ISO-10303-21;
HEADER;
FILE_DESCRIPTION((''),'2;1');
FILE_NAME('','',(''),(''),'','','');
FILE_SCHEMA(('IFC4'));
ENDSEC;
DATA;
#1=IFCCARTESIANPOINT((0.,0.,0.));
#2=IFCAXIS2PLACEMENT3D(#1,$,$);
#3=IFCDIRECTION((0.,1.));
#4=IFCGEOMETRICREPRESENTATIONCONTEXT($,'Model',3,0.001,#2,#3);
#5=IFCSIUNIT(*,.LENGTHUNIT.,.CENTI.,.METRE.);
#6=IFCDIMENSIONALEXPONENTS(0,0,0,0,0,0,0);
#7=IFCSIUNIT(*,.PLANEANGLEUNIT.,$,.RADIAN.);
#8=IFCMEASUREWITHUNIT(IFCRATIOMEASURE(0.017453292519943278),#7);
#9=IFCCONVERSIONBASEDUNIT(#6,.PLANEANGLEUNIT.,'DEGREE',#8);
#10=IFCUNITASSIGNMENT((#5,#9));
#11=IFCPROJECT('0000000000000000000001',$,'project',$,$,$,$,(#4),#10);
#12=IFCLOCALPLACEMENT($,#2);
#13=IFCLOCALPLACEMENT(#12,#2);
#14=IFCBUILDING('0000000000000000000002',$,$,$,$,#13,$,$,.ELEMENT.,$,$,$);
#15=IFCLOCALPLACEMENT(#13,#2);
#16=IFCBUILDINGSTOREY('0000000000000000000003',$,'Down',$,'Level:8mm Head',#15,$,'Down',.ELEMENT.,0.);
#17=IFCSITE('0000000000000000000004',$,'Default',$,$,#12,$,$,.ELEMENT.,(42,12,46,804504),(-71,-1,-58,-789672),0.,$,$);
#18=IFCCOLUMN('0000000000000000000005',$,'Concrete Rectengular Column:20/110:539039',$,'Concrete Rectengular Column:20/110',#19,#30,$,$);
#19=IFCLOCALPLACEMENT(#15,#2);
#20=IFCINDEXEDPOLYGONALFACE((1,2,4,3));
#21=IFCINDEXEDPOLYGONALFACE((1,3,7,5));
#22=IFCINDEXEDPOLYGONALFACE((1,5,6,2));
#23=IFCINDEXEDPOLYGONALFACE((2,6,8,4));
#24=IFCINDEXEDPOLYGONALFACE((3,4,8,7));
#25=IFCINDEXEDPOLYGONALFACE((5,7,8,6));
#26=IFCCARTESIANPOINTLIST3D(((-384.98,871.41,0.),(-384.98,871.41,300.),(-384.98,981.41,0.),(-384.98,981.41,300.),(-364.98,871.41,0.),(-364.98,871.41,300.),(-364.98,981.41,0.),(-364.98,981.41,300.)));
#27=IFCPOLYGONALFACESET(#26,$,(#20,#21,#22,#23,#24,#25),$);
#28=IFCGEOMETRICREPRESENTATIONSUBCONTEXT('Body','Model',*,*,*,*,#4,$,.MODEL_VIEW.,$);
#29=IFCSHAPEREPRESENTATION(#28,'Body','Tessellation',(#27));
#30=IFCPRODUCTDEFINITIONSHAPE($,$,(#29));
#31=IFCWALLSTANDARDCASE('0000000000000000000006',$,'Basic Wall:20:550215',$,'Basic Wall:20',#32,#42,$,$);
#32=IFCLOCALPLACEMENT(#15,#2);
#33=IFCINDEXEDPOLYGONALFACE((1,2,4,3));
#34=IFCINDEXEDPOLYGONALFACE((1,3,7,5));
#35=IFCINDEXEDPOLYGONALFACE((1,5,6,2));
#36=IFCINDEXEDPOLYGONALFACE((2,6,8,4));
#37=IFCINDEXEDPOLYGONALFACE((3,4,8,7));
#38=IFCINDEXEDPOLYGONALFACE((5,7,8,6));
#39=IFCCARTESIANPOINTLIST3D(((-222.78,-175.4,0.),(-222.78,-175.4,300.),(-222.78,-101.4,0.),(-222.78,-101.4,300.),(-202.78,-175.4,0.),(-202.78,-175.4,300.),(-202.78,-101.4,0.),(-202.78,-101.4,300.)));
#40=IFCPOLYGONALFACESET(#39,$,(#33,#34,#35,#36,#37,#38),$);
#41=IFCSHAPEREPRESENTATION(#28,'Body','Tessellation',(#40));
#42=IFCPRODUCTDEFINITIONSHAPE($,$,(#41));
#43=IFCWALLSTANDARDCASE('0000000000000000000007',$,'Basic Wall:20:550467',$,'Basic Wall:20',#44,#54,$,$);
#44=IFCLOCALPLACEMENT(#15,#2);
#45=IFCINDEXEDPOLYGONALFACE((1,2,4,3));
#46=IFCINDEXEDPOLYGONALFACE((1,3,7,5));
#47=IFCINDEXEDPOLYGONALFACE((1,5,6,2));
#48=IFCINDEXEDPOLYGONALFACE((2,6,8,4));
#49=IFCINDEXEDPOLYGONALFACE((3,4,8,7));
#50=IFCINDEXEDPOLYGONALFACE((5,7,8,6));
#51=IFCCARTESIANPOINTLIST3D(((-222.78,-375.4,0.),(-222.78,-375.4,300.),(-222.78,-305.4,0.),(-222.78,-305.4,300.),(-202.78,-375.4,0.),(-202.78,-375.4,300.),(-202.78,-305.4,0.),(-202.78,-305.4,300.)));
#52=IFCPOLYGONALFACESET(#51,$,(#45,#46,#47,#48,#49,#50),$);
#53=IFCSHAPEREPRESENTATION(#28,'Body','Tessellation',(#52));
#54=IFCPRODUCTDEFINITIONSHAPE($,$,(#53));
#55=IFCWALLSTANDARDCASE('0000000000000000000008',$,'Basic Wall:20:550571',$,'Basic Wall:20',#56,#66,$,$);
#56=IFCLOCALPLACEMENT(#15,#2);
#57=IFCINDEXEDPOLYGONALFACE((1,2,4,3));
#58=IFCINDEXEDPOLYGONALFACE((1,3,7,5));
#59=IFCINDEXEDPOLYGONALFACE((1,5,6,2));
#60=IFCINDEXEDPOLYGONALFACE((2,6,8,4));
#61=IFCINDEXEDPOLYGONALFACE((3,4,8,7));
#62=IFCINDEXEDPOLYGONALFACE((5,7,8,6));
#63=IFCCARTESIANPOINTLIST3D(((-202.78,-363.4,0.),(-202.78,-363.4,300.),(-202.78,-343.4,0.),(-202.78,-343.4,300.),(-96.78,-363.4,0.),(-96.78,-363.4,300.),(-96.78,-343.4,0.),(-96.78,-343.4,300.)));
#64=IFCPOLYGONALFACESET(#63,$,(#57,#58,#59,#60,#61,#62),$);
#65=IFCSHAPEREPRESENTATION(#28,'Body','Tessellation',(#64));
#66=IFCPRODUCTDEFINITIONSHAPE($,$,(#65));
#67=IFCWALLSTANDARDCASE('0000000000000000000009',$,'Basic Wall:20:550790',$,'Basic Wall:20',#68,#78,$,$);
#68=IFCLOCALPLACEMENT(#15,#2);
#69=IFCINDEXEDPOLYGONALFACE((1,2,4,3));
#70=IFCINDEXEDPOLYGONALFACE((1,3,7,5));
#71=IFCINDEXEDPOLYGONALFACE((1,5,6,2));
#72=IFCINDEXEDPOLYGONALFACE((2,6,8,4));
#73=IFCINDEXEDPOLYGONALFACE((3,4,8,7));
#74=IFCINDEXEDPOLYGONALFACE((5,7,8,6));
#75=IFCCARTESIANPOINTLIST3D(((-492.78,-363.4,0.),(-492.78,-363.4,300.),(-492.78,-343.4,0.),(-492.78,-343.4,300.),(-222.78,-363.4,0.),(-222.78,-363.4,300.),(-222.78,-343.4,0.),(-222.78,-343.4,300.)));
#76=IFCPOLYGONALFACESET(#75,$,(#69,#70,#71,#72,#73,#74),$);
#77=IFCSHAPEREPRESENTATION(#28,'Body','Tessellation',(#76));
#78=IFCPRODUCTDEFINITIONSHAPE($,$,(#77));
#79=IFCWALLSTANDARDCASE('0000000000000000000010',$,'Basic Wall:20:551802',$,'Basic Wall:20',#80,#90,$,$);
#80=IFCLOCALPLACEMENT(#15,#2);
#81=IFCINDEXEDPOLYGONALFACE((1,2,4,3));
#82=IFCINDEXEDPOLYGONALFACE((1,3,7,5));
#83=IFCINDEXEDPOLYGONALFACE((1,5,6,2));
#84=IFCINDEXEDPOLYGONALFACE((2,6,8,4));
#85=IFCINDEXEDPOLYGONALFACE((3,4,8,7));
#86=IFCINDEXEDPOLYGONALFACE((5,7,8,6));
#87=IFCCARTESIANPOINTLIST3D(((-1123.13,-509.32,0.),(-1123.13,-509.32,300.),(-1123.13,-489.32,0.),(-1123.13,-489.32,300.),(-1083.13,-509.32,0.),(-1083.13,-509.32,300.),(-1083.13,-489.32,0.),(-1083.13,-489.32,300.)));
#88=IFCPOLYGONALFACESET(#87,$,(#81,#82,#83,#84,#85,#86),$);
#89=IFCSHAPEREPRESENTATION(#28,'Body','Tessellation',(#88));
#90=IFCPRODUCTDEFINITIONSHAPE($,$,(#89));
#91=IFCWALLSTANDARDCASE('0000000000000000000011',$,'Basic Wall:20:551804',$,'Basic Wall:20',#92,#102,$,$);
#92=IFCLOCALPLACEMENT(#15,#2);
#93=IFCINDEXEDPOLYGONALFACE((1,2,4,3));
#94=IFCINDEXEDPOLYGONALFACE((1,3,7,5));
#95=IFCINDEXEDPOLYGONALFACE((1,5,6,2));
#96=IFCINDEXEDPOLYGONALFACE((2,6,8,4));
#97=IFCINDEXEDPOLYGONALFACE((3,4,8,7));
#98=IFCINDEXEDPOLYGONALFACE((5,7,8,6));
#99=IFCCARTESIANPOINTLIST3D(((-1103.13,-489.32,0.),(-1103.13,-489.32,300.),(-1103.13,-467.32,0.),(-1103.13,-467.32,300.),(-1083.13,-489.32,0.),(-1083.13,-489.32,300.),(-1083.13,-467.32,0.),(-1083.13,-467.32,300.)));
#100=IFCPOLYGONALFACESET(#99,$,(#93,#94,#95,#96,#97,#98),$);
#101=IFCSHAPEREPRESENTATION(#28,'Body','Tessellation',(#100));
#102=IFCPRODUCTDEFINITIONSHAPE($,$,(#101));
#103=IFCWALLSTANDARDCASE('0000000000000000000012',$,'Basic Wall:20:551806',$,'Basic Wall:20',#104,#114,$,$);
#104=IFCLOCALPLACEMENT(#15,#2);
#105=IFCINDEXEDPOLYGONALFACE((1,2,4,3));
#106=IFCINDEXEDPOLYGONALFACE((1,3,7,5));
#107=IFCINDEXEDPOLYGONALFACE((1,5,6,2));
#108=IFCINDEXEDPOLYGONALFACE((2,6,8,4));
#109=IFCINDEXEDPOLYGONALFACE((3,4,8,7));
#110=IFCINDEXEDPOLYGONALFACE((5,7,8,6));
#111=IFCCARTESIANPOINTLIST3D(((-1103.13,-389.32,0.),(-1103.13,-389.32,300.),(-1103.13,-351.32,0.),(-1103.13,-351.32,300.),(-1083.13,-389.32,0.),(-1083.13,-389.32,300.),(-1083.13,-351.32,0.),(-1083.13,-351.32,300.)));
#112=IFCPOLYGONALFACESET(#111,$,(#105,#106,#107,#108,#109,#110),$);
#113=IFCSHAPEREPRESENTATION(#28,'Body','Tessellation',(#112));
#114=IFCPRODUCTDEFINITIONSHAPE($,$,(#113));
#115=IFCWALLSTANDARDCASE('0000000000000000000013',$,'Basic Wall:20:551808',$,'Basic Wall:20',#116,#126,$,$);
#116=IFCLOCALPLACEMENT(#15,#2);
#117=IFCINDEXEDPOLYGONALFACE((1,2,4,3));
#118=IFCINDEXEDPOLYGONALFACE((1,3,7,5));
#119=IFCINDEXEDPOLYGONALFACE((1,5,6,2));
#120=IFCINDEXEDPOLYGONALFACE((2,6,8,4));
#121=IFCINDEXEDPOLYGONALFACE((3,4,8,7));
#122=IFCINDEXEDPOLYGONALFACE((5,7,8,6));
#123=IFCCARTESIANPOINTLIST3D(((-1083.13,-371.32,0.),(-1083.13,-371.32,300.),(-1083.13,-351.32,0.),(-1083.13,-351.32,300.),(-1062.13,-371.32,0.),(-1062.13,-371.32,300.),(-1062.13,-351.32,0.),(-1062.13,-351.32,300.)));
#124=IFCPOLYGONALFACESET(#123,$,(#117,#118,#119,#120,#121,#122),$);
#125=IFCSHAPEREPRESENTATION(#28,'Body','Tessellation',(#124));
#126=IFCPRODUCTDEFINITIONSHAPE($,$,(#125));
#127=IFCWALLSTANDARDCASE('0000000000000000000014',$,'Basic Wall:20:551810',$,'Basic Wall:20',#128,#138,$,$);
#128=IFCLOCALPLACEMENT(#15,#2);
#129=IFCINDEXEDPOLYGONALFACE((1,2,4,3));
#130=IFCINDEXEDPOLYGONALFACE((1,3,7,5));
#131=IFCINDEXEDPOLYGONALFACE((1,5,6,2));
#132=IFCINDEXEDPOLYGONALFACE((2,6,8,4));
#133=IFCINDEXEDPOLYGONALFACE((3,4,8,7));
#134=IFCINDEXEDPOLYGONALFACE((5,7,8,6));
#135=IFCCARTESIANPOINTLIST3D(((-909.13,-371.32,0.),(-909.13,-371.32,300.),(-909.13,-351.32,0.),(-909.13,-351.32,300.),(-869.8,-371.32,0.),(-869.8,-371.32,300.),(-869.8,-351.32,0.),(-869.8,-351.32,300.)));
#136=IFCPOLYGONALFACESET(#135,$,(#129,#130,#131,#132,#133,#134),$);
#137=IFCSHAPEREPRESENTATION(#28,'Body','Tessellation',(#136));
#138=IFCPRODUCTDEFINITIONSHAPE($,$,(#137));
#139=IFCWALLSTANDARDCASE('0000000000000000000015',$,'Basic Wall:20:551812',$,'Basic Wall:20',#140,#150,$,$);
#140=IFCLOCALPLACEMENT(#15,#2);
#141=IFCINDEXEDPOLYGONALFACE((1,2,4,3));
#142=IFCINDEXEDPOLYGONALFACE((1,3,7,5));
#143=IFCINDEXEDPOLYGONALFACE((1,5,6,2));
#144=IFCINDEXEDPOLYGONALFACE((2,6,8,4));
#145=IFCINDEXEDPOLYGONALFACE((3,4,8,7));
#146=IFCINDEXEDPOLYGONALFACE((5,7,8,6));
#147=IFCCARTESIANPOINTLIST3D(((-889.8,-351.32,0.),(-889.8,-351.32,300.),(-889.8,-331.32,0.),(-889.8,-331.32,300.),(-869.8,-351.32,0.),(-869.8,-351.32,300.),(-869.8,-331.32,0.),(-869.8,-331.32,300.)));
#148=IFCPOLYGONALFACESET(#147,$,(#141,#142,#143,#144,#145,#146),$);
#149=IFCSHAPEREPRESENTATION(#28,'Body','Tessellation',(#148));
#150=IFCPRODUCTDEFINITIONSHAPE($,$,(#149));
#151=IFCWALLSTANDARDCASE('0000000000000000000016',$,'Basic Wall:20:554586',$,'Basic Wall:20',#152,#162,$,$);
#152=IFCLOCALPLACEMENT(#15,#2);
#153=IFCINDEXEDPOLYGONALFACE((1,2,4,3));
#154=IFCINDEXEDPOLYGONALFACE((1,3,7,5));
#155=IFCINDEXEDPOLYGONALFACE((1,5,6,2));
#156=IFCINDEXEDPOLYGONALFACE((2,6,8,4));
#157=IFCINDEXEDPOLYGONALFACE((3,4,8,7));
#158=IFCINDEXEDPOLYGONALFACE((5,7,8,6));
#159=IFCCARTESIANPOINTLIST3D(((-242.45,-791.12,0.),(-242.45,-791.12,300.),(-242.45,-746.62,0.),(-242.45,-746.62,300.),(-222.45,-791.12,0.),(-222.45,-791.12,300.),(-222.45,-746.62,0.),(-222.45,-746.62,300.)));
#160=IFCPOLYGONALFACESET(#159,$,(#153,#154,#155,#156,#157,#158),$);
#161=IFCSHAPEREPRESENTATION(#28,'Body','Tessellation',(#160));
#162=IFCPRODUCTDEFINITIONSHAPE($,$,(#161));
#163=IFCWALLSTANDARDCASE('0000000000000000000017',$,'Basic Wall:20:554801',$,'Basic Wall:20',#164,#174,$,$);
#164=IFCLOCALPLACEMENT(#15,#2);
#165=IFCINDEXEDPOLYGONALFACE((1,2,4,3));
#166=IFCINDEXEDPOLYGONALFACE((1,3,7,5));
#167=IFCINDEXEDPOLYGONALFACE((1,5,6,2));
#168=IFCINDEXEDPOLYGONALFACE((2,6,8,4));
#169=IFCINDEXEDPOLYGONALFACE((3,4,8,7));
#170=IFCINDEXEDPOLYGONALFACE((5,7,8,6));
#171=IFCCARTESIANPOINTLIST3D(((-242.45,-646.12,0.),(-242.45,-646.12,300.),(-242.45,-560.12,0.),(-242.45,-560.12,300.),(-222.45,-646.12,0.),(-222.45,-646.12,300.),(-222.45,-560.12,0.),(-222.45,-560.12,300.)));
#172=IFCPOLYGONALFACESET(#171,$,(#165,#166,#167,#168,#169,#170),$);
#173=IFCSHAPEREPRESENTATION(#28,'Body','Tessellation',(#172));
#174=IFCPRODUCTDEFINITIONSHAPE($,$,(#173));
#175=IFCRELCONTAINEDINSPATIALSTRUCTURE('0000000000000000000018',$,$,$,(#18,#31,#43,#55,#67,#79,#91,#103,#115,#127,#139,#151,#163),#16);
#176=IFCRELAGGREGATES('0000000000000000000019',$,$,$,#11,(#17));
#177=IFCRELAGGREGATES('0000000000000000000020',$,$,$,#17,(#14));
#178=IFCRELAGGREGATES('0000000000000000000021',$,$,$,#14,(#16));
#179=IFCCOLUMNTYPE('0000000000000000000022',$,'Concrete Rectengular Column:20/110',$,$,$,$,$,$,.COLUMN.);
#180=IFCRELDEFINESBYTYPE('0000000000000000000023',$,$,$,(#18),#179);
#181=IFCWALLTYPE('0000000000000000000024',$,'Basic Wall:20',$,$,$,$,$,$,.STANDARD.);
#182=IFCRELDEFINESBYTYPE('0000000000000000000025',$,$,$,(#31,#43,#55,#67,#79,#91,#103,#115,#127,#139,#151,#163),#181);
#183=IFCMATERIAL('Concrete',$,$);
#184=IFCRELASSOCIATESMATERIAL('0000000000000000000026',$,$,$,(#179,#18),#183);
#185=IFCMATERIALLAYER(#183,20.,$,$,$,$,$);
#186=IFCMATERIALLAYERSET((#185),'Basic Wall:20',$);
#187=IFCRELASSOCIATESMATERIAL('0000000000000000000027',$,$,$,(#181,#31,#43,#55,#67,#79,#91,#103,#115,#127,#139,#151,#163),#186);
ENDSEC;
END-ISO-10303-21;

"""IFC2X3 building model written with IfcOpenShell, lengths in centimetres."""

from ifc_helpers import new_model, entity, si_unit, converted_unit, direction, frame, frame_2d, origin, place, context, subcontext, project, spatial, rectangle, extrude, source, transform, mapped, material, layer, layer_set, layer_usage, type_object, type_shapes, element, save


model = new_model("IFC2X3")

# Units and contexts
model_context = context("Model", 3, precision=0.001, world=origin(), true_north=direction((0.0, 1.0)))
body_context = subcontext(model_context, "Body", "Model", "MODEL_VIEW")
ifc_project = project(units=[si_unit("LENGTHUNIT", "METRE", prefix="CENTI"), converted_unit("PLANEANGLEUNIT", "DEGREE", entity("IfcRatioMeasure", 0.017453292519943278), si_unit("PLANEANGLEUNIT", "RADIAN"), dimensions=[0, 0, 0, 0, 0, 0, 0])], contexts=[model_context])

# Site, building, storey
site_placement = place(None, origin())
site = spatial("IfcSite", under=ifc_project, at=site_placement, Name="Default", CompositionType="ELEMENT", RefLatitude=(42, 12, 46, 804504), RefLongitude=(-71, -1, -58, -789672), RefElevation=0.0)
building_placement = place(site_placement, origin())
building = spatial("IfcBuilding", under=site, at=building_placement, CompositionType="ELEMENT")
storey_placement = place(building_placement, origin())
storey = spatial("IfcBuildingStorey", under=building, at=storey_placement, Name="Down", ObjectType="Level:8mm Head", LongName="Down", CompositionType="ELEMENT", Elevation=0.0)

# Column
ifc_material = material(Name="Concrete")
column_type = type_object("IfcColumnType", Name="Concrete Rectengular Column:20/110", PredefinedType="COLUMN", material=ifc_material)
shared_shape = source(origin(), body_context, "Body", "SweptSolid", [
    extrude(rectangle(XDim=110.0, YDim=20.0, at=frame_2d((0.0, 0.0), x_axis=(1.0, 0.0))), frame((-374.98, 926.41, 0.0), z_axis=(0.0, 0.0, 1.0), x_axis=(0.0, -1.0, 0.0)), (0.0, 0.0, 1.0), 300.0),
])
type_shapes(column_type, [shared_shape])
column_placement = place(storey_placement, origin())
element("IfcColumn", 1, at=column_placement, inside=storey, type_object=column_type, material=ifc_material, Name="Concrete Rectengular Column:20/110:539039", ObjectType="Concrete Rectengular Column:20/110", context=body_context, shape_type="MappedRepresentation", body=[
    mapped(shared_shape, transform((0.0, 0.0, 0.0), scale=1.0)),
])

# Walls
ifc_layer_1 = layer(ifc_material, 20.0)
ifc_layer_set_1 = layer_set([ifc_layer_1], Name="Basic Wall:20")
ifc_layer_usage_1 = layer_usage(ifc_layer_set_1, "AXIS2", "NEGATIVE", 10.0)
wall_type_1 = type_object("IfcWallType", Name="Basic Wall:20", PredefinedType="STANDARD", material=ifc_layer_set_1)
wall_1_placement = place(storey_placement, frame((-212.78, -101.4, 0.0), z_axis=(0.0, 0.0, 1.0), x_axis=(0.0, -1.0, 0.0)))
element("IfcWallStandardCase", 2, at=wall_1_placement, inside=storey, type_object=wall_type_1, material=ifc_layer_usage_1, Name="Basic Wall:20:550215", ObjectType="Basic Wall:20", context=body_context, shape_type="SweptSolid", body=[
    extrude(rectangle(XDim=74.0, YDim=20.0, at=frame_2d((37.0, 0.0), x_axis=(-1.0, 0.0))), origin(), (0.0, 0.0, 1.0), 300.0),
])
ifc_layer_usage_2 = layer_usage(ifc_layer_set_1, "AXIS2", "NEGATIVE", 10.0)
wall_2_placement = place(storey_placement, frame((-212.78, -305.4, 0.0), z_axis=(0.0, 0.0, 1.0), x_axis=(0.0, -1.0, 0.0)))
element("IfcWallStandardCase", 3, at=wall_2_placement, inside=storey, type_object=wall_type_1, material=ifc_layer_usage_2, Name="Basic Wall:20:550467", ObjectType="Basic Wall:20", context=body_context, shape_type="SweptSolid", body=[
    extrude(rectangle(XDim=70.0, YDim=20.0, at=frame_2d((35.0, 0.0), x_axis=(-1.0, 0.0))), origin(), (0.0, 0.0, 1.0), 300.0),
])
ifc_layer_usage_3 = layer_usage(ifc_layer_set_1, "AXIS2", "NEGATIVE", 10.0)
wall_3_placement = place(storey_placement, frame((-202.78, -353.4, 0.0)))
element("IfcWallStandardCase", 4, at=wall_3_placement, inside=storey, type_object=wall_type_1, material=ifc_layer_usage_3, Name="Basic Wall:20:550571", ObjectType="Basic Wall:20", context=body_context, shape_type="SweptSolid", body=[
    extrude(rectangle(XDim=106.0, YDim=20.0, at=frame_2d((53.0, 0.0), x_axis=(-1.0, 0.0))), origin(), (0.0, 0.0, 1.0), 300.0),
])
ifc_layer_usage_4 = layer_usage(ifc_layer_set_1, "AXIS2", "POSITIVE", -10.0)
wall_4_placement = place(storey_placement, frame((-222.78, -353.4, 0.0), z_axis=(0.0, 0.0, 1.0), x_axis=(-1.0, 0.0, 0.0)))
element("IfcWallStandardCase", 5, at=wall_4_placement, inside=storey, type_object=wall_type_1, material=ifc_layer_usage_4, Name="Basic Wall:20:550790", ObjectType="Basic Wall:20", context=body_context, shape_type="SweptSolid", body=[
    extrude(rectangle(XDim=270.0, YDim=20.0, at=frame_2d((135.0, 0.0), x_axis=(-1.0, 0.0))), origin(), (0.0, 0.0, 1.0), 300.0),
])
ifc_layer_usage_5 = layer_usage(ifc_layer_set_1, "AXIS2", "NEGATIVE", 10.0)
wall_5_placement = place(storey_placement, frame((-1123.13, -499.32, 0.0)))
element("IfcWallStandardCase", 6, at=wall_5_placement, inside=storey, type_object=wall_type_1, material=ifc_layer_usage_5, Name="Basic Wall:20:551802", ObjectType="Basic Wall:20", context=body_context, shape_type="SweptSolid", body=[
    extrude(rectangle(XDim=40.0, YDim=20.0, at=frame_2d((20.0, 0.0), x_axis=(-1.0, 0.0))), origin(), (0.0, 0.0, 1.0), 300.0),
])
ifc_layer_usage_6 = layer_usage(ifc_layer_set_1, "AXIS2", "POSITIVE", -10.0)
wall_6_placement = place(storey_placement, frame((-1093.13, -489.32, 0.0), z_axis=(0.0, 0.0, 1.0), x_axis=(0.0, 1.0, 0.0)))
element("IfcWallStandardCase", 7, at=wall_6_placement, inside=storey, type_object=wall_type_1, material=ifc_layer_usage_6, Name="Basic Wall:20:551804", ObjectType="Basic Wall:20", context=body_context, shape_type="SweptSolid", body=[
    extrude(rectangle(XDim=22.0, YDim=20.0, at=frame_2d((11.0, 0.0), x_axis=(-1.0, 0.0))), origin(), (0.0, 0.0, 1.0), 300.0),
])
ifc_layer_usage_7 = layer_usage(ifc_layer_set_1, "AXIS2", "POSITIVE", -10.0)
wall_7_placement = place(storey_placement, frame((-1093.13, -389.32, 0.0), z_axis=(0.0, 0.0, 1.0), x_axis=(0.0, 1.0, 0.0)))
element("IfcWallStandardCase", 8, at=wall_7_placement, inside=storey, type_object=wall_type_1, material=ifc_layer_usage_7, Name="Basic Wall:20:551806", ObjectType="Basic Wall:20", context=body_context, shape_type="SweptSolid", body=[
    extrude(rectangle(XDim=38.0, YDim=20.0, at=frame_2d((19.0, 0.0), x_axis=(-1.0, 0.0))), origin(), (0.0, 0.0, 1.0), 300.0),
])
ifc_layer_usage_8 = layer_usage(ifc_layer_set_1, "AXIS2", "NEGATIVE", 10.0)
wall_8_placement = place(storey_placement, frame((-1083.13, -361.32, 0.0)))
element("IfcWallStandardCase", 9, at=wall_8_placement, inside=storey, type_object=wall_type_1, material=ifc_layer_usage_8, Name="Basic Wall:20:551808", ObjectType="Basic Wall:20", context=body_context, shape_type="SweptSolid", body=[
    extrude(rectangle(XDim=21.0, YDim=20.0, at=frame_2d((10.5, 0.0), x_axis=(-1.0, 0.0))), origin(), (0.0, 0.0, 1.0), 300.0),
])
ifc_layer_usage_9 = layer_usage(ifc_layer_set_1, "AXIS2", "NEGATIVE", 10.0)
wall_9_placement = place(storey_placement, frame((-909.13, -361.32, 0.0)))
element("IfcWallStandardCase", 10, at=wall_9_placement, inside=storey, type_object=wall_type_1, material=ifc_layer_usage_9, Name="Basic Wall:20:551810", ObjectType="Basic Wall:20", context=body_context, shape_type="SweptSolid", body=[
    extrude(rectangle(XDim=39.33, YDim=20.0, at=frame_2d((19.67, 0.0), x_axis=(-1.0, 0.0))), origin(), (0.0, 0.0, 1.0), 300.0),
])
ifc_layer_usage_10 = layer_usage(ifc_layer_set_1, "AXIS2", "POSITIVE", -10.0)
wall_10_placement = place(storey_placement, frame((-879.8, -351.32, 0.0), z_axis=(0.0, 0.0, 1.0), x_axis=(0.0, 1.0, 0.0)))
element("IfcWallStandardCase", 11, at=wall_10_placement, inside=storey, type_object=wall_type_1, material=ifc_layer_usage_10, Name="Basic Wall:20:551812", ObjectType="Basic Wall:20", context=body_context, shape_type="SweptSolid", body=[
    extrude(rectangle(XDim=20.0, YDim=20.0, at=frame_2d((10.0, 0.0), x_axis=(-1.0, 0.0))), origin(), (0.0, 0.0, 1.0), 300.0),
])
ifc_layer_usage_11 = layer_usage(ifc_layer_set_1, "AXIS2", "NEGATIVE", 10.0)
wall_11_placement = place(storey_placement, frame((-232.45, -791.12, 0.0), z_axis=(0.0, 0.0, 1.0), x_axis=(0.0, 1.0, 0.0)))
element("IfcWallStandardCase", 12, at=wall_11_placement, inside=storey, type_object=wall_type_1, material=ifc_layer_usage_11, Name="Basic Wall:20:554586", ObjectType="Basic Wall:20", context=body_context, shape_type="SweptSolid", body=[
    extrude(rectangle(XDim=44.5, YDim=20.0, at=frame_2d((22.25, 0.0), x_axis=(-1.0, 0.0))), origin(), (0.0, 0.0, 1.0), 300.0),
])
ifc_layer_usage_12 = layer_usage(ifc_layer_set_1, "AXIS2", "NEGATIVE", 10.0)
wall_12_placement = place(storey_placement, frame((-232.45, -646.12, 0.0), z_axis=(0.0, 0.0, 1.0), x_axis=(0.0, 1.0, 0.0)))
element("IfcWallStandardCase", 13, at=wall_12_placement, inside=storey, type_object=wall_type_1, material=ifc_layer_usage_12, Name="Basic Wall:20:554801", ObjectType="Basic Wall:20", context=body_context, shape_type="SweptSolid", body=[
    extrude(rectangle(XDim=86.0, YDim=20.0, at=frame_2d((43.0, 0.0), x_axis=(-1.0, 0.0))), origin(), (0.0, 0.0, 1.0), 300.0),
])

save(model, "model.ifc")
